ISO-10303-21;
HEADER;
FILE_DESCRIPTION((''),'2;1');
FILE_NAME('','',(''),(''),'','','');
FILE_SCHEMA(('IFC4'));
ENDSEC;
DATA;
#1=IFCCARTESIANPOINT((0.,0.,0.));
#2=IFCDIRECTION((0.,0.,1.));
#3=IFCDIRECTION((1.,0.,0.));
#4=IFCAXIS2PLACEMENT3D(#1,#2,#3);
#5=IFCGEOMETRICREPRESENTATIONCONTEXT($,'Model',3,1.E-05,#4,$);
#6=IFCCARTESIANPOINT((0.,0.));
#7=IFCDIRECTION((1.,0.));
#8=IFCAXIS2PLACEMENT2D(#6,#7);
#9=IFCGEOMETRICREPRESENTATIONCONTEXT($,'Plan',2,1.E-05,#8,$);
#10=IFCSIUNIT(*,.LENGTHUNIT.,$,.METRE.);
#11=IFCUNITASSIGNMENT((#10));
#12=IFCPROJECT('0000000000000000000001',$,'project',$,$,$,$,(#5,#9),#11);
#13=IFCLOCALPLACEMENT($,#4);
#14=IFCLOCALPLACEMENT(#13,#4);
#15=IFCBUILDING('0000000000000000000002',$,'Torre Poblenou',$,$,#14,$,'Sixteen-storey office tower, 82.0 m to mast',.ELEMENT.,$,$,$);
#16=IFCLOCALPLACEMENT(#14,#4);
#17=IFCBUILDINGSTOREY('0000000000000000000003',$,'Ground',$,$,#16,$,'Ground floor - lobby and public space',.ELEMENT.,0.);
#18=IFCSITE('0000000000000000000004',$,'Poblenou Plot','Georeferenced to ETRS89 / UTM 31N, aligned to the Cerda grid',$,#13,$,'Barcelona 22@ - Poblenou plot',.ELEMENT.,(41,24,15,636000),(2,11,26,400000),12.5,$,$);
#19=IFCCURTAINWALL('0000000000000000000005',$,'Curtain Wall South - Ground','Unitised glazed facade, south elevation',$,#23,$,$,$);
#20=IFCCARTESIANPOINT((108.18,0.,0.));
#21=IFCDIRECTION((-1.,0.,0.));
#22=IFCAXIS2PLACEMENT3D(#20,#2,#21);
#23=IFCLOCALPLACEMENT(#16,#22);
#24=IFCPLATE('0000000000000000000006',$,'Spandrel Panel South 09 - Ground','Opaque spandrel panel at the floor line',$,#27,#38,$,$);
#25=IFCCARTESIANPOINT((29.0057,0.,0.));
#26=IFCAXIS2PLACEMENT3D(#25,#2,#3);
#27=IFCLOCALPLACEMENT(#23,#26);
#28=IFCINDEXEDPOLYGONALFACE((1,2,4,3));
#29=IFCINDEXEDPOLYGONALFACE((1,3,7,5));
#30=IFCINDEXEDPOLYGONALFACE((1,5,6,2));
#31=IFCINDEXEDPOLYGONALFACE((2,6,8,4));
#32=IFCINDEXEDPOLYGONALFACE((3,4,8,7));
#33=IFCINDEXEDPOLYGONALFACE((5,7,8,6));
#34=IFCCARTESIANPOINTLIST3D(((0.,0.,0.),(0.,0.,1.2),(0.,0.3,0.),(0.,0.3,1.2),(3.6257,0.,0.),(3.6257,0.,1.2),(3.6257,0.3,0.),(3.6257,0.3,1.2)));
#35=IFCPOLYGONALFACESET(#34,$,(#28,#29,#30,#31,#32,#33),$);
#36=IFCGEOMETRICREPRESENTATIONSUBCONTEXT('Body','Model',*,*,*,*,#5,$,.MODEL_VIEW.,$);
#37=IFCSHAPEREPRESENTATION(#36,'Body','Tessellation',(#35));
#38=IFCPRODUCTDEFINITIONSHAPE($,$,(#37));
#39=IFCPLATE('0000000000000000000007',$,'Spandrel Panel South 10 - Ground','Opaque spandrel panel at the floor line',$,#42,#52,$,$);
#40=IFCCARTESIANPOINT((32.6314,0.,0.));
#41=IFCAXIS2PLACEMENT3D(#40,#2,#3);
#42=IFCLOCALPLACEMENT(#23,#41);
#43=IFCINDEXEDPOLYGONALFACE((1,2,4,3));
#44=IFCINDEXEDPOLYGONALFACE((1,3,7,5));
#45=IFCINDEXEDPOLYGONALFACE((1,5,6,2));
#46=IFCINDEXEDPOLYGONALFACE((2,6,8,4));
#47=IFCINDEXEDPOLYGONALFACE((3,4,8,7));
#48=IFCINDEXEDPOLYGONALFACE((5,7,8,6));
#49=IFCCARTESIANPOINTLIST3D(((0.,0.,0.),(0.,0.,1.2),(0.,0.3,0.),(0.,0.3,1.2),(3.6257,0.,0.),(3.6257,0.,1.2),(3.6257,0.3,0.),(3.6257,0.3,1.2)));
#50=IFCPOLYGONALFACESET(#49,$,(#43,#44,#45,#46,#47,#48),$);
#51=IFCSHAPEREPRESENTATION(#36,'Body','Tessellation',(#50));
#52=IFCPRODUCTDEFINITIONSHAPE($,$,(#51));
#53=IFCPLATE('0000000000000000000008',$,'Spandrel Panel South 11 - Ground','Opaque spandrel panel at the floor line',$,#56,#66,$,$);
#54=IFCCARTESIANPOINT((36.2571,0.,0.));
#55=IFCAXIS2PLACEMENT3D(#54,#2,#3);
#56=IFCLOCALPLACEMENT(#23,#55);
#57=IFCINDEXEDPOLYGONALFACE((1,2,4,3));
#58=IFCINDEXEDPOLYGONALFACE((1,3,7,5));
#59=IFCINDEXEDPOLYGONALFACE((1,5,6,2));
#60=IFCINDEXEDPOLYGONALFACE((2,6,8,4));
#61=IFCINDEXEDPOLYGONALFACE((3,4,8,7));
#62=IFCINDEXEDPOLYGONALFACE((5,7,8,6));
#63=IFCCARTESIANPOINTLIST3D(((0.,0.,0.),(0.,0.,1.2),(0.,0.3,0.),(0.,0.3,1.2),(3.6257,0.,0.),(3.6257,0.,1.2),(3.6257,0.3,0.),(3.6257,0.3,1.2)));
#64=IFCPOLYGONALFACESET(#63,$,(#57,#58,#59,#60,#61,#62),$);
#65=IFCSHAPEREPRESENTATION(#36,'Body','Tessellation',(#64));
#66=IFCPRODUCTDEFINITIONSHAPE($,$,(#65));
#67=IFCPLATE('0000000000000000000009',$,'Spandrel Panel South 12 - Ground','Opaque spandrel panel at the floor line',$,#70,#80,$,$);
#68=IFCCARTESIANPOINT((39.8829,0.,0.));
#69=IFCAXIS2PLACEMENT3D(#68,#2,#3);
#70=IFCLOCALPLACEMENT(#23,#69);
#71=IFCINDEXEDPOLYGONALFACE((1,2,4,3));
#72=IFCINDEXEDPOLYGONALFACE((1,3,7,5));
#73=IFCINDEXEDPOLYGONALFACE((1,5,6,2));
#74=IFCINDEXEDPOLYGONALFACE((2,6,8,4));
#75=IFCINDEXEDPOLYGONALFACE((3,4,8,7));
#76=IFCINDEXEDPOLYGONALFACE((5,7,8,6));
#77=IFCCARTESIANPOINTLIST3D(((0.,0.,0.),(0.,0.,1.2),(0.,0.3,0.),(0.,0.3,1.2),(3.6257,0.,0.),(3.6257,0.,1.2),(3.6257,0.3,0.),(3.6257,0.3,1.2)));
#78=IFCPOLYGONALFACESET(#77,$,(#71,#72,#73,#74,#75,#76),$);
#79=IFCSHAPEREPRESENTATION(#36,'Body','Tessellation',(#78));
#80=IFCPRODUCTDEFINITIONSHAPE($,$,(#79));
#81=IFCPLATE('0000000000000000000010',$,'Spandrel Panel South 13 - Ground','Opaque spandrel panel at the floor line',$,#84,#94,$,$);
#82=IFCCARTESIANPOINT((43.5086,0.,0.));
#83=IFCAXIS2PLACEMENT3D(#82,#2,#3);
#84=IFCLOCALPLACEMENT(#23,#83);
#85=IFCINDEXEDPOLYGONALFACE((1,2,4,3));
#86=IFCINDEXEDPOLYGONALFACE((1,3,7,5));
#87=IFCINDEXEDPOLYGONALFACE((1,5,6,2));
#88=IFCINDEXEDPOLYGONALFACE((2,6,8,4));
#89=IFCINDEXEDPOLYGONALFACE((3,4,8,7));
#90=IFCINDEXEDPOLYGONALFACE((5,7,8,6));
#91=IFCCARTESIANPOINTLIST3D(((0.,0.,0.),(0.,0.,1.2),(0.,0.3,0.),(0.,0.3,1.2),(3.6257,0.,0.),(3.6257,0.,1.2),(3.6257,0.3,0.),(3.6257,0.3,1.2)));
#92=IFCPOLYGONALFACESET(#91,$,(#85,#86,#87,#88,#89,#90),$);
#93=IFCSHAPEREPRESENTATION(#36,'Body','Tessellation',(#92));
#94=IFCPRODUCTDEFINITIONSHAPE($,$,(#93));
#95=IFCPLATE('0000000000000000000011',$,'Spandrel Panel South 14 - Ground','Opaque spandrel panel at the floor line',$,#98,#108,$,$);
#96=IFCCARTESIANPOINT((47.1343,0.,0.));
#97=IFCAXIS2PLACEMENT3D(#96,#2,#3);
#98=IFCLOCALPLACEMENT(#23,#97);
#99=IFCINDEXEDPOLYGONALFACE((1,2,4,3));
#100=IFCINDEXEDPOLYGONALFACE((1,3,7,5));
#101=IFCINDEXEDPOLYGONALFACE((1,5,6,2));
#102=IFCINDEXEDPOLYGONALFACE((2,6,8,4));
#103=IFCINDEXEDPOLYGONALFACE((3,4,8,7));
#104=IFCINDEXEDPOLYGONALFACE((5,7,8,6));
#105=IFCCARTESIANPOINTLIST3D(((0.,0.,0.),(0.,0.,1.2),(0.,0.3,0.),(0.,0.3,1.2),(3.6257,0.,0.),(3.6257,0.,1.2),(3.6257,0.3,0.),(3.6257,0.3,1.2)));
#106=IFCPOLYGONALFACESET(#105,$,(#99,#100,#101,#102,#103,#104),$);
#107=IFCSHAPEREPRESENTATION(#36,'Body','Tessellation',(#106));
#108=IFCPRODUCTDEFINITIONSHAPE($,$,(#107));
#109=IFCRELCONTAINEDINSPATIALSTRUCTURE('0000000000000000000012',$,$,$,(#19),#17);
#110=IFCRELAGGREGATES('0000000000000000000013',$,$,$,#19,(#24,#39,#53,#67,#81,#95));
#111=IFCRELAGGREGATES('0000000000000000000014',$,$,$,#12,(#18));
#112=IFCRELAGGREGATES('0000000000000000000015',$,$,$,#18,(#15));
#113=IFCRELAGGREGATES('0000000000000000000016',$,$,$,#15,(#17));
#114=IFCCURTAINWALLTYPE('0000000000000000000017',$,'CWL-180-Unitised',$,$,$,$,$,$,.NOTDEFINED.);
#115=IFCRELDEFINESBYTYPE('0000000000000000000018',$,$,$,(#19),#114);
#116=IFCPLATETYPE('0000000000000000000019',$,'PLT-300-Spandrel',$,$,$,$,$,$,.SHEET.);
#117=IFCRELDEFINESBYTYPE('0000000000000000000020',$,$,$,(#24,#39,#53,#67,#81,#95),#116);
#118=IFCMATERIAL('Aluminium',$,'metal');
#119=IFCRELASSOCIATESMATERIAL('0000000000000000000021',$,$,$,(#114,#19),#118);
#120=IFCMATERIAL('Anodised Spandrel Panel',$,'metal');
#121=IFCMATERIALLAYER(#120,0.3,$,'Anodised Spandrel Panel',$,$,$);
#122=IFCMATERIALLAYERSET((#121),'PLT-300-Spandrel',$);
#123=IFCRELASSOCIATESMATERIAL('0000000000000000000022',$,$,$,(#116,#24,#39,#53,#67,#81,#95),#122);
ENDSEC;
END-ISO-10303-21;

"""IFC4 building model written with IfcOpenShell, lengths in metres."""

from ifc_helpers import new_model, si_unit, frame, origin_with_axes, origin_2d_with_axis, place, context, subcontext, project, spatial, line, indexed_curve, outline, extrude, material, layer, layer_set, layer_usage, type_object, element, aggregate, save


model = new_model("IFC4")

# Units and contexts
model_context = context("Model", 3, precision=1e-05, world=origin_with_axes())
plan_context = context("Plan", 2, precision=1e-05, world=origin_2d_with_axis())
body_context = subcontext(model_context, "Body", "Model", "MODEL_VIEW")
ifc_project = project(units=[si_unit("LENGTHUNIT", "METRE")], contexts=[model_context, plan_context])

# Site, building, storey
site_placement = place(None, origin_with_axes())
site = spatial("IfcSite", under=ifc_project, at=site_placement, Name="Poblenou Plot", Description="Georeferenced to ETRS89 / UTM 31N, aligned to the Cerda grid", LongName="Barcelona 22@ - Poblenou plot", CompositionType="ELEMENT", RefLatitude=(41, 24, 15, 636000), RefLongitude=(2, 11, 26, 400000), RefElevation=12.5)
building_placement = place(site_placement, origin_with_axes())
building = spatial("IfcBuilding", under=site, at=building_placement, Name="Torre Poblenou", LongName="Sixteen-storey office tower, 82.0 m to mast", CompositionType="ELEMENT")
storey_placement = place(building_placement, origin_with_axes())
storey = spatial("IfcBuildingStorey", under=building, at=storey_placement, Name="Ground", LongName="Ground floor - lobby and public space", CompositionType="ELEMENT", Elevation=0.0)

# Curtain wall
ifc_material_1 = material(Name="Aluminium", Category="metal")
curtain_wall_type = type_object("IfcCurtainWallType", Name="CWL-180-Unitised", PredefinedType="NOTDEFINED", material=ifc_material_1)
curtain_wall_1_placement = place(storey_placement, frame((108.18, 0.0, 0.0), z_axis=(0.0, 0.0, 1.0), x_axis=(-1.0, 0.0, 0.0)))
curtain_wall_1 = element("IfcCurtainWall", 1, at=curtain_wall_1_placement, inside=storey, type_object=curtain_wall_type, material=ifc_material_1, Name="Curtain Wall South - Ground", Description="Unitised glazed facade, south elevation")

# Plates
ifc_material_2 = material(Name="Anodised Spandrel Panel", Category="metal")
ifc_layer_1 = layer(ifc_material_2, 0.3, Name="Anodised Spandrel Panel")
ifc_layer_set_1 = layer_set([ifc_layer_1], Name="PLT-300-Spandrel")
ifc_layer_usage_1 = layer_usage(ifc_layer_set_1, "AXIS2", "POSITIVE", 0.0)
plate_type_1 = type_object("IfcPlateType", Name="PLT-300-Spandrel", PredefinedType="SHEET", material=ifc_layer_set_1)
plate_1_placement = place(curtain_wall_1_placement, frame((29.0057, 0.0, 0.0), z_axis=(0.0, 0.0, 1.0), x_axis=(1.0, 0.0, 0.0)))
plate_1 = element("IfcPlate", 2, at=plate_1_placement, type_object=plate_type_1, material=ifc_layer_usage_1, Name="Spandrel Panel South 09 - Ground", Description="Opaque spandrel panel at the floor line", context=body_context, shape_type="SweptSolid", body=[
    extrude(outline(indexed_curve([(0.0, 0.0), (3.6257, 0.0), (3.6257, 0.3), (0.0, 0.3)], segments=[line(1, 2, 3, 4, 1)])), origin_with_axes(), (0.0, 0.0, 1.0), 1.2),
])
ifc_layer_usage_2 = layer_usage(ifc_layer_set_1, "AXIS2", "POSITIVE", 0.0)
plate_2_placement = place(curtain_wall_1_placement, frame((32.6314, 0.0, 0.0), z_axis=(0.0, 0.0, 1.0), x_axis=(1.0, 0.0, 0.0)))
plate_2 = element("IfcPlate", 3, at=plate_2_placement, type_object=plate_type_1, material=ifc_layer_usage_2, Name="Spandrel Panel South 10 - Ground", Description="Opaque spandrel panel at the floor line", context=body_context, shape_type="SweptSolid", body=[
    extrude(outline(indexed_curve([(0.0, 0.0), (3.6257, 0.0), (3.6257, 0.3), (0.0, 0.3)], segments=[line(1, 2, 3, 4, 1)])), origin_with_axes(), (0.0, 0.0, 1.0), 1.2),
])
ifc_layer_usage_3 = layer_usage(ifc_layer_set_1, "AXIS2", "POSITIVE", 0.0)
plate_3_placement = place(curtain_wall_1_placement, frame((36.2571, 0.0, 0.0), z_axis=(0.0, 0.0, 1.0), x_axis=(1.0, 0.0, 0.0)))
plate_3 = element("IfcPlate", 4, at=plate_3_placement, type_object=plate_type_1, material=ifc_layer_usage_3, Name="Spandrel Panel South 11 - Ground", Description="Opaque spandrel panel at the floor line", context=body_context, shape_type="SweptSolid", body=[
    extrude(outline(indexed_curve([(0.0, 0.0), (3.6257, 0.0), (3.6257, 0.3), (0.0, 0.3)], segments=[line(1, 2, 3, 4, 1)])), origin_with_axes(), (0.0, 0.0, 1.0), 1.2),
])
ifc_layer_usage_4 = layer_usage(ifc_layer_set_1, "AXIS2", "POSITIVE", 0.0)
plate_4_placement = place(curtain_wall_1_placement, frame((39.8829, 0.0, 0.0), z_axis=(0.0, 0.0, 1.0), x_axis=(1.0, 0.0, 0.0)))
plate_4 = element("IfcPlate", 5, at=plate_4_placement, type_object=plate_type_1, material=ifc_layer_usage_4, Name="Spandrel Panel South 12 - Ground", Description="Opaque spandrel panel at the floor line", context=body_context, shape_type="SweptSolid", body=[
    extrude(outline(indexed_curve([(0.0, 0.0), (3.6257, 0.0), (3.6257, 0.3), (0.0, 0.3)], segments=[line(1, 2, 3, 4, 1)])), origin_with_axes(), (0.0, 0.0, 1.0), 1.2),
])
ifc_layer_usage_5 = layer_usage(ifc_layer_set_1, "AXIS2", "POSITIVE", 0.0)
plate_5_placement = place(curtain_wall_1_placement, frame((43.5086, 0.0, 0.0), z_axis=(0.0, 0.0, 1.0), x_axis=(1.0, 0.0, 0.0)))
plate_5 = element("IfcPlate", 6, at=plate_5_placement, type_object=plate_type_1, material=ifc_layer_usage_5, Name="Spandrel Panel South 13 - Ground", Description="Opaque spandrel panel at the floor line", context=body_context, shape_type="SweptSolid", body=[
    extrude(outline(indexed_curve([(0.0, 0.0), (3.6257, 0.0), (3.6257, 0.3), (0.0, 0.3)], segments=[line(1, 2, 3, 4, 1)])), origin_with_axes(), (0.0, 0.0, 1.0), 1.2),
])
ifc_layer_usage_6 = layer_usage(ifc_layer_set_1, "AXIS2", "POSITIVE", 0.0)
plate_6_placement = place(curtain_wall_1_placement, frame((47.1343, 0.0, 0.0), z_axis=(0.0, 0.0, 1.0), x_axis=(1.0, 0.0, 0.0)))
plate_6 = element("IfcPlate", 7, at=plate_6_placement, type_object=plate_type_1, material=ifc_layer_usage_6, Name="Spandrel Panel South 14 - Ground", Description="Opaque spandrel panel at the floor line", context=body_context, shape_type="SweptSolid", body=[
    extrude(outline(indexed_curve([(0.0, 0.0), (3.6257, 0.0), (3.6257, 0.3), (0.0, 0.3)], segments=[line(1, 2, 3, 4, 1)])), origin_with_axes(), (0.0, 0.0, 1.0), 1.2),
])
aggregate(curtain_wall_1, [plate_1, plate_2, plate_3, plate_4, plate_5, plate_6])

save(model, "model.ifc")
